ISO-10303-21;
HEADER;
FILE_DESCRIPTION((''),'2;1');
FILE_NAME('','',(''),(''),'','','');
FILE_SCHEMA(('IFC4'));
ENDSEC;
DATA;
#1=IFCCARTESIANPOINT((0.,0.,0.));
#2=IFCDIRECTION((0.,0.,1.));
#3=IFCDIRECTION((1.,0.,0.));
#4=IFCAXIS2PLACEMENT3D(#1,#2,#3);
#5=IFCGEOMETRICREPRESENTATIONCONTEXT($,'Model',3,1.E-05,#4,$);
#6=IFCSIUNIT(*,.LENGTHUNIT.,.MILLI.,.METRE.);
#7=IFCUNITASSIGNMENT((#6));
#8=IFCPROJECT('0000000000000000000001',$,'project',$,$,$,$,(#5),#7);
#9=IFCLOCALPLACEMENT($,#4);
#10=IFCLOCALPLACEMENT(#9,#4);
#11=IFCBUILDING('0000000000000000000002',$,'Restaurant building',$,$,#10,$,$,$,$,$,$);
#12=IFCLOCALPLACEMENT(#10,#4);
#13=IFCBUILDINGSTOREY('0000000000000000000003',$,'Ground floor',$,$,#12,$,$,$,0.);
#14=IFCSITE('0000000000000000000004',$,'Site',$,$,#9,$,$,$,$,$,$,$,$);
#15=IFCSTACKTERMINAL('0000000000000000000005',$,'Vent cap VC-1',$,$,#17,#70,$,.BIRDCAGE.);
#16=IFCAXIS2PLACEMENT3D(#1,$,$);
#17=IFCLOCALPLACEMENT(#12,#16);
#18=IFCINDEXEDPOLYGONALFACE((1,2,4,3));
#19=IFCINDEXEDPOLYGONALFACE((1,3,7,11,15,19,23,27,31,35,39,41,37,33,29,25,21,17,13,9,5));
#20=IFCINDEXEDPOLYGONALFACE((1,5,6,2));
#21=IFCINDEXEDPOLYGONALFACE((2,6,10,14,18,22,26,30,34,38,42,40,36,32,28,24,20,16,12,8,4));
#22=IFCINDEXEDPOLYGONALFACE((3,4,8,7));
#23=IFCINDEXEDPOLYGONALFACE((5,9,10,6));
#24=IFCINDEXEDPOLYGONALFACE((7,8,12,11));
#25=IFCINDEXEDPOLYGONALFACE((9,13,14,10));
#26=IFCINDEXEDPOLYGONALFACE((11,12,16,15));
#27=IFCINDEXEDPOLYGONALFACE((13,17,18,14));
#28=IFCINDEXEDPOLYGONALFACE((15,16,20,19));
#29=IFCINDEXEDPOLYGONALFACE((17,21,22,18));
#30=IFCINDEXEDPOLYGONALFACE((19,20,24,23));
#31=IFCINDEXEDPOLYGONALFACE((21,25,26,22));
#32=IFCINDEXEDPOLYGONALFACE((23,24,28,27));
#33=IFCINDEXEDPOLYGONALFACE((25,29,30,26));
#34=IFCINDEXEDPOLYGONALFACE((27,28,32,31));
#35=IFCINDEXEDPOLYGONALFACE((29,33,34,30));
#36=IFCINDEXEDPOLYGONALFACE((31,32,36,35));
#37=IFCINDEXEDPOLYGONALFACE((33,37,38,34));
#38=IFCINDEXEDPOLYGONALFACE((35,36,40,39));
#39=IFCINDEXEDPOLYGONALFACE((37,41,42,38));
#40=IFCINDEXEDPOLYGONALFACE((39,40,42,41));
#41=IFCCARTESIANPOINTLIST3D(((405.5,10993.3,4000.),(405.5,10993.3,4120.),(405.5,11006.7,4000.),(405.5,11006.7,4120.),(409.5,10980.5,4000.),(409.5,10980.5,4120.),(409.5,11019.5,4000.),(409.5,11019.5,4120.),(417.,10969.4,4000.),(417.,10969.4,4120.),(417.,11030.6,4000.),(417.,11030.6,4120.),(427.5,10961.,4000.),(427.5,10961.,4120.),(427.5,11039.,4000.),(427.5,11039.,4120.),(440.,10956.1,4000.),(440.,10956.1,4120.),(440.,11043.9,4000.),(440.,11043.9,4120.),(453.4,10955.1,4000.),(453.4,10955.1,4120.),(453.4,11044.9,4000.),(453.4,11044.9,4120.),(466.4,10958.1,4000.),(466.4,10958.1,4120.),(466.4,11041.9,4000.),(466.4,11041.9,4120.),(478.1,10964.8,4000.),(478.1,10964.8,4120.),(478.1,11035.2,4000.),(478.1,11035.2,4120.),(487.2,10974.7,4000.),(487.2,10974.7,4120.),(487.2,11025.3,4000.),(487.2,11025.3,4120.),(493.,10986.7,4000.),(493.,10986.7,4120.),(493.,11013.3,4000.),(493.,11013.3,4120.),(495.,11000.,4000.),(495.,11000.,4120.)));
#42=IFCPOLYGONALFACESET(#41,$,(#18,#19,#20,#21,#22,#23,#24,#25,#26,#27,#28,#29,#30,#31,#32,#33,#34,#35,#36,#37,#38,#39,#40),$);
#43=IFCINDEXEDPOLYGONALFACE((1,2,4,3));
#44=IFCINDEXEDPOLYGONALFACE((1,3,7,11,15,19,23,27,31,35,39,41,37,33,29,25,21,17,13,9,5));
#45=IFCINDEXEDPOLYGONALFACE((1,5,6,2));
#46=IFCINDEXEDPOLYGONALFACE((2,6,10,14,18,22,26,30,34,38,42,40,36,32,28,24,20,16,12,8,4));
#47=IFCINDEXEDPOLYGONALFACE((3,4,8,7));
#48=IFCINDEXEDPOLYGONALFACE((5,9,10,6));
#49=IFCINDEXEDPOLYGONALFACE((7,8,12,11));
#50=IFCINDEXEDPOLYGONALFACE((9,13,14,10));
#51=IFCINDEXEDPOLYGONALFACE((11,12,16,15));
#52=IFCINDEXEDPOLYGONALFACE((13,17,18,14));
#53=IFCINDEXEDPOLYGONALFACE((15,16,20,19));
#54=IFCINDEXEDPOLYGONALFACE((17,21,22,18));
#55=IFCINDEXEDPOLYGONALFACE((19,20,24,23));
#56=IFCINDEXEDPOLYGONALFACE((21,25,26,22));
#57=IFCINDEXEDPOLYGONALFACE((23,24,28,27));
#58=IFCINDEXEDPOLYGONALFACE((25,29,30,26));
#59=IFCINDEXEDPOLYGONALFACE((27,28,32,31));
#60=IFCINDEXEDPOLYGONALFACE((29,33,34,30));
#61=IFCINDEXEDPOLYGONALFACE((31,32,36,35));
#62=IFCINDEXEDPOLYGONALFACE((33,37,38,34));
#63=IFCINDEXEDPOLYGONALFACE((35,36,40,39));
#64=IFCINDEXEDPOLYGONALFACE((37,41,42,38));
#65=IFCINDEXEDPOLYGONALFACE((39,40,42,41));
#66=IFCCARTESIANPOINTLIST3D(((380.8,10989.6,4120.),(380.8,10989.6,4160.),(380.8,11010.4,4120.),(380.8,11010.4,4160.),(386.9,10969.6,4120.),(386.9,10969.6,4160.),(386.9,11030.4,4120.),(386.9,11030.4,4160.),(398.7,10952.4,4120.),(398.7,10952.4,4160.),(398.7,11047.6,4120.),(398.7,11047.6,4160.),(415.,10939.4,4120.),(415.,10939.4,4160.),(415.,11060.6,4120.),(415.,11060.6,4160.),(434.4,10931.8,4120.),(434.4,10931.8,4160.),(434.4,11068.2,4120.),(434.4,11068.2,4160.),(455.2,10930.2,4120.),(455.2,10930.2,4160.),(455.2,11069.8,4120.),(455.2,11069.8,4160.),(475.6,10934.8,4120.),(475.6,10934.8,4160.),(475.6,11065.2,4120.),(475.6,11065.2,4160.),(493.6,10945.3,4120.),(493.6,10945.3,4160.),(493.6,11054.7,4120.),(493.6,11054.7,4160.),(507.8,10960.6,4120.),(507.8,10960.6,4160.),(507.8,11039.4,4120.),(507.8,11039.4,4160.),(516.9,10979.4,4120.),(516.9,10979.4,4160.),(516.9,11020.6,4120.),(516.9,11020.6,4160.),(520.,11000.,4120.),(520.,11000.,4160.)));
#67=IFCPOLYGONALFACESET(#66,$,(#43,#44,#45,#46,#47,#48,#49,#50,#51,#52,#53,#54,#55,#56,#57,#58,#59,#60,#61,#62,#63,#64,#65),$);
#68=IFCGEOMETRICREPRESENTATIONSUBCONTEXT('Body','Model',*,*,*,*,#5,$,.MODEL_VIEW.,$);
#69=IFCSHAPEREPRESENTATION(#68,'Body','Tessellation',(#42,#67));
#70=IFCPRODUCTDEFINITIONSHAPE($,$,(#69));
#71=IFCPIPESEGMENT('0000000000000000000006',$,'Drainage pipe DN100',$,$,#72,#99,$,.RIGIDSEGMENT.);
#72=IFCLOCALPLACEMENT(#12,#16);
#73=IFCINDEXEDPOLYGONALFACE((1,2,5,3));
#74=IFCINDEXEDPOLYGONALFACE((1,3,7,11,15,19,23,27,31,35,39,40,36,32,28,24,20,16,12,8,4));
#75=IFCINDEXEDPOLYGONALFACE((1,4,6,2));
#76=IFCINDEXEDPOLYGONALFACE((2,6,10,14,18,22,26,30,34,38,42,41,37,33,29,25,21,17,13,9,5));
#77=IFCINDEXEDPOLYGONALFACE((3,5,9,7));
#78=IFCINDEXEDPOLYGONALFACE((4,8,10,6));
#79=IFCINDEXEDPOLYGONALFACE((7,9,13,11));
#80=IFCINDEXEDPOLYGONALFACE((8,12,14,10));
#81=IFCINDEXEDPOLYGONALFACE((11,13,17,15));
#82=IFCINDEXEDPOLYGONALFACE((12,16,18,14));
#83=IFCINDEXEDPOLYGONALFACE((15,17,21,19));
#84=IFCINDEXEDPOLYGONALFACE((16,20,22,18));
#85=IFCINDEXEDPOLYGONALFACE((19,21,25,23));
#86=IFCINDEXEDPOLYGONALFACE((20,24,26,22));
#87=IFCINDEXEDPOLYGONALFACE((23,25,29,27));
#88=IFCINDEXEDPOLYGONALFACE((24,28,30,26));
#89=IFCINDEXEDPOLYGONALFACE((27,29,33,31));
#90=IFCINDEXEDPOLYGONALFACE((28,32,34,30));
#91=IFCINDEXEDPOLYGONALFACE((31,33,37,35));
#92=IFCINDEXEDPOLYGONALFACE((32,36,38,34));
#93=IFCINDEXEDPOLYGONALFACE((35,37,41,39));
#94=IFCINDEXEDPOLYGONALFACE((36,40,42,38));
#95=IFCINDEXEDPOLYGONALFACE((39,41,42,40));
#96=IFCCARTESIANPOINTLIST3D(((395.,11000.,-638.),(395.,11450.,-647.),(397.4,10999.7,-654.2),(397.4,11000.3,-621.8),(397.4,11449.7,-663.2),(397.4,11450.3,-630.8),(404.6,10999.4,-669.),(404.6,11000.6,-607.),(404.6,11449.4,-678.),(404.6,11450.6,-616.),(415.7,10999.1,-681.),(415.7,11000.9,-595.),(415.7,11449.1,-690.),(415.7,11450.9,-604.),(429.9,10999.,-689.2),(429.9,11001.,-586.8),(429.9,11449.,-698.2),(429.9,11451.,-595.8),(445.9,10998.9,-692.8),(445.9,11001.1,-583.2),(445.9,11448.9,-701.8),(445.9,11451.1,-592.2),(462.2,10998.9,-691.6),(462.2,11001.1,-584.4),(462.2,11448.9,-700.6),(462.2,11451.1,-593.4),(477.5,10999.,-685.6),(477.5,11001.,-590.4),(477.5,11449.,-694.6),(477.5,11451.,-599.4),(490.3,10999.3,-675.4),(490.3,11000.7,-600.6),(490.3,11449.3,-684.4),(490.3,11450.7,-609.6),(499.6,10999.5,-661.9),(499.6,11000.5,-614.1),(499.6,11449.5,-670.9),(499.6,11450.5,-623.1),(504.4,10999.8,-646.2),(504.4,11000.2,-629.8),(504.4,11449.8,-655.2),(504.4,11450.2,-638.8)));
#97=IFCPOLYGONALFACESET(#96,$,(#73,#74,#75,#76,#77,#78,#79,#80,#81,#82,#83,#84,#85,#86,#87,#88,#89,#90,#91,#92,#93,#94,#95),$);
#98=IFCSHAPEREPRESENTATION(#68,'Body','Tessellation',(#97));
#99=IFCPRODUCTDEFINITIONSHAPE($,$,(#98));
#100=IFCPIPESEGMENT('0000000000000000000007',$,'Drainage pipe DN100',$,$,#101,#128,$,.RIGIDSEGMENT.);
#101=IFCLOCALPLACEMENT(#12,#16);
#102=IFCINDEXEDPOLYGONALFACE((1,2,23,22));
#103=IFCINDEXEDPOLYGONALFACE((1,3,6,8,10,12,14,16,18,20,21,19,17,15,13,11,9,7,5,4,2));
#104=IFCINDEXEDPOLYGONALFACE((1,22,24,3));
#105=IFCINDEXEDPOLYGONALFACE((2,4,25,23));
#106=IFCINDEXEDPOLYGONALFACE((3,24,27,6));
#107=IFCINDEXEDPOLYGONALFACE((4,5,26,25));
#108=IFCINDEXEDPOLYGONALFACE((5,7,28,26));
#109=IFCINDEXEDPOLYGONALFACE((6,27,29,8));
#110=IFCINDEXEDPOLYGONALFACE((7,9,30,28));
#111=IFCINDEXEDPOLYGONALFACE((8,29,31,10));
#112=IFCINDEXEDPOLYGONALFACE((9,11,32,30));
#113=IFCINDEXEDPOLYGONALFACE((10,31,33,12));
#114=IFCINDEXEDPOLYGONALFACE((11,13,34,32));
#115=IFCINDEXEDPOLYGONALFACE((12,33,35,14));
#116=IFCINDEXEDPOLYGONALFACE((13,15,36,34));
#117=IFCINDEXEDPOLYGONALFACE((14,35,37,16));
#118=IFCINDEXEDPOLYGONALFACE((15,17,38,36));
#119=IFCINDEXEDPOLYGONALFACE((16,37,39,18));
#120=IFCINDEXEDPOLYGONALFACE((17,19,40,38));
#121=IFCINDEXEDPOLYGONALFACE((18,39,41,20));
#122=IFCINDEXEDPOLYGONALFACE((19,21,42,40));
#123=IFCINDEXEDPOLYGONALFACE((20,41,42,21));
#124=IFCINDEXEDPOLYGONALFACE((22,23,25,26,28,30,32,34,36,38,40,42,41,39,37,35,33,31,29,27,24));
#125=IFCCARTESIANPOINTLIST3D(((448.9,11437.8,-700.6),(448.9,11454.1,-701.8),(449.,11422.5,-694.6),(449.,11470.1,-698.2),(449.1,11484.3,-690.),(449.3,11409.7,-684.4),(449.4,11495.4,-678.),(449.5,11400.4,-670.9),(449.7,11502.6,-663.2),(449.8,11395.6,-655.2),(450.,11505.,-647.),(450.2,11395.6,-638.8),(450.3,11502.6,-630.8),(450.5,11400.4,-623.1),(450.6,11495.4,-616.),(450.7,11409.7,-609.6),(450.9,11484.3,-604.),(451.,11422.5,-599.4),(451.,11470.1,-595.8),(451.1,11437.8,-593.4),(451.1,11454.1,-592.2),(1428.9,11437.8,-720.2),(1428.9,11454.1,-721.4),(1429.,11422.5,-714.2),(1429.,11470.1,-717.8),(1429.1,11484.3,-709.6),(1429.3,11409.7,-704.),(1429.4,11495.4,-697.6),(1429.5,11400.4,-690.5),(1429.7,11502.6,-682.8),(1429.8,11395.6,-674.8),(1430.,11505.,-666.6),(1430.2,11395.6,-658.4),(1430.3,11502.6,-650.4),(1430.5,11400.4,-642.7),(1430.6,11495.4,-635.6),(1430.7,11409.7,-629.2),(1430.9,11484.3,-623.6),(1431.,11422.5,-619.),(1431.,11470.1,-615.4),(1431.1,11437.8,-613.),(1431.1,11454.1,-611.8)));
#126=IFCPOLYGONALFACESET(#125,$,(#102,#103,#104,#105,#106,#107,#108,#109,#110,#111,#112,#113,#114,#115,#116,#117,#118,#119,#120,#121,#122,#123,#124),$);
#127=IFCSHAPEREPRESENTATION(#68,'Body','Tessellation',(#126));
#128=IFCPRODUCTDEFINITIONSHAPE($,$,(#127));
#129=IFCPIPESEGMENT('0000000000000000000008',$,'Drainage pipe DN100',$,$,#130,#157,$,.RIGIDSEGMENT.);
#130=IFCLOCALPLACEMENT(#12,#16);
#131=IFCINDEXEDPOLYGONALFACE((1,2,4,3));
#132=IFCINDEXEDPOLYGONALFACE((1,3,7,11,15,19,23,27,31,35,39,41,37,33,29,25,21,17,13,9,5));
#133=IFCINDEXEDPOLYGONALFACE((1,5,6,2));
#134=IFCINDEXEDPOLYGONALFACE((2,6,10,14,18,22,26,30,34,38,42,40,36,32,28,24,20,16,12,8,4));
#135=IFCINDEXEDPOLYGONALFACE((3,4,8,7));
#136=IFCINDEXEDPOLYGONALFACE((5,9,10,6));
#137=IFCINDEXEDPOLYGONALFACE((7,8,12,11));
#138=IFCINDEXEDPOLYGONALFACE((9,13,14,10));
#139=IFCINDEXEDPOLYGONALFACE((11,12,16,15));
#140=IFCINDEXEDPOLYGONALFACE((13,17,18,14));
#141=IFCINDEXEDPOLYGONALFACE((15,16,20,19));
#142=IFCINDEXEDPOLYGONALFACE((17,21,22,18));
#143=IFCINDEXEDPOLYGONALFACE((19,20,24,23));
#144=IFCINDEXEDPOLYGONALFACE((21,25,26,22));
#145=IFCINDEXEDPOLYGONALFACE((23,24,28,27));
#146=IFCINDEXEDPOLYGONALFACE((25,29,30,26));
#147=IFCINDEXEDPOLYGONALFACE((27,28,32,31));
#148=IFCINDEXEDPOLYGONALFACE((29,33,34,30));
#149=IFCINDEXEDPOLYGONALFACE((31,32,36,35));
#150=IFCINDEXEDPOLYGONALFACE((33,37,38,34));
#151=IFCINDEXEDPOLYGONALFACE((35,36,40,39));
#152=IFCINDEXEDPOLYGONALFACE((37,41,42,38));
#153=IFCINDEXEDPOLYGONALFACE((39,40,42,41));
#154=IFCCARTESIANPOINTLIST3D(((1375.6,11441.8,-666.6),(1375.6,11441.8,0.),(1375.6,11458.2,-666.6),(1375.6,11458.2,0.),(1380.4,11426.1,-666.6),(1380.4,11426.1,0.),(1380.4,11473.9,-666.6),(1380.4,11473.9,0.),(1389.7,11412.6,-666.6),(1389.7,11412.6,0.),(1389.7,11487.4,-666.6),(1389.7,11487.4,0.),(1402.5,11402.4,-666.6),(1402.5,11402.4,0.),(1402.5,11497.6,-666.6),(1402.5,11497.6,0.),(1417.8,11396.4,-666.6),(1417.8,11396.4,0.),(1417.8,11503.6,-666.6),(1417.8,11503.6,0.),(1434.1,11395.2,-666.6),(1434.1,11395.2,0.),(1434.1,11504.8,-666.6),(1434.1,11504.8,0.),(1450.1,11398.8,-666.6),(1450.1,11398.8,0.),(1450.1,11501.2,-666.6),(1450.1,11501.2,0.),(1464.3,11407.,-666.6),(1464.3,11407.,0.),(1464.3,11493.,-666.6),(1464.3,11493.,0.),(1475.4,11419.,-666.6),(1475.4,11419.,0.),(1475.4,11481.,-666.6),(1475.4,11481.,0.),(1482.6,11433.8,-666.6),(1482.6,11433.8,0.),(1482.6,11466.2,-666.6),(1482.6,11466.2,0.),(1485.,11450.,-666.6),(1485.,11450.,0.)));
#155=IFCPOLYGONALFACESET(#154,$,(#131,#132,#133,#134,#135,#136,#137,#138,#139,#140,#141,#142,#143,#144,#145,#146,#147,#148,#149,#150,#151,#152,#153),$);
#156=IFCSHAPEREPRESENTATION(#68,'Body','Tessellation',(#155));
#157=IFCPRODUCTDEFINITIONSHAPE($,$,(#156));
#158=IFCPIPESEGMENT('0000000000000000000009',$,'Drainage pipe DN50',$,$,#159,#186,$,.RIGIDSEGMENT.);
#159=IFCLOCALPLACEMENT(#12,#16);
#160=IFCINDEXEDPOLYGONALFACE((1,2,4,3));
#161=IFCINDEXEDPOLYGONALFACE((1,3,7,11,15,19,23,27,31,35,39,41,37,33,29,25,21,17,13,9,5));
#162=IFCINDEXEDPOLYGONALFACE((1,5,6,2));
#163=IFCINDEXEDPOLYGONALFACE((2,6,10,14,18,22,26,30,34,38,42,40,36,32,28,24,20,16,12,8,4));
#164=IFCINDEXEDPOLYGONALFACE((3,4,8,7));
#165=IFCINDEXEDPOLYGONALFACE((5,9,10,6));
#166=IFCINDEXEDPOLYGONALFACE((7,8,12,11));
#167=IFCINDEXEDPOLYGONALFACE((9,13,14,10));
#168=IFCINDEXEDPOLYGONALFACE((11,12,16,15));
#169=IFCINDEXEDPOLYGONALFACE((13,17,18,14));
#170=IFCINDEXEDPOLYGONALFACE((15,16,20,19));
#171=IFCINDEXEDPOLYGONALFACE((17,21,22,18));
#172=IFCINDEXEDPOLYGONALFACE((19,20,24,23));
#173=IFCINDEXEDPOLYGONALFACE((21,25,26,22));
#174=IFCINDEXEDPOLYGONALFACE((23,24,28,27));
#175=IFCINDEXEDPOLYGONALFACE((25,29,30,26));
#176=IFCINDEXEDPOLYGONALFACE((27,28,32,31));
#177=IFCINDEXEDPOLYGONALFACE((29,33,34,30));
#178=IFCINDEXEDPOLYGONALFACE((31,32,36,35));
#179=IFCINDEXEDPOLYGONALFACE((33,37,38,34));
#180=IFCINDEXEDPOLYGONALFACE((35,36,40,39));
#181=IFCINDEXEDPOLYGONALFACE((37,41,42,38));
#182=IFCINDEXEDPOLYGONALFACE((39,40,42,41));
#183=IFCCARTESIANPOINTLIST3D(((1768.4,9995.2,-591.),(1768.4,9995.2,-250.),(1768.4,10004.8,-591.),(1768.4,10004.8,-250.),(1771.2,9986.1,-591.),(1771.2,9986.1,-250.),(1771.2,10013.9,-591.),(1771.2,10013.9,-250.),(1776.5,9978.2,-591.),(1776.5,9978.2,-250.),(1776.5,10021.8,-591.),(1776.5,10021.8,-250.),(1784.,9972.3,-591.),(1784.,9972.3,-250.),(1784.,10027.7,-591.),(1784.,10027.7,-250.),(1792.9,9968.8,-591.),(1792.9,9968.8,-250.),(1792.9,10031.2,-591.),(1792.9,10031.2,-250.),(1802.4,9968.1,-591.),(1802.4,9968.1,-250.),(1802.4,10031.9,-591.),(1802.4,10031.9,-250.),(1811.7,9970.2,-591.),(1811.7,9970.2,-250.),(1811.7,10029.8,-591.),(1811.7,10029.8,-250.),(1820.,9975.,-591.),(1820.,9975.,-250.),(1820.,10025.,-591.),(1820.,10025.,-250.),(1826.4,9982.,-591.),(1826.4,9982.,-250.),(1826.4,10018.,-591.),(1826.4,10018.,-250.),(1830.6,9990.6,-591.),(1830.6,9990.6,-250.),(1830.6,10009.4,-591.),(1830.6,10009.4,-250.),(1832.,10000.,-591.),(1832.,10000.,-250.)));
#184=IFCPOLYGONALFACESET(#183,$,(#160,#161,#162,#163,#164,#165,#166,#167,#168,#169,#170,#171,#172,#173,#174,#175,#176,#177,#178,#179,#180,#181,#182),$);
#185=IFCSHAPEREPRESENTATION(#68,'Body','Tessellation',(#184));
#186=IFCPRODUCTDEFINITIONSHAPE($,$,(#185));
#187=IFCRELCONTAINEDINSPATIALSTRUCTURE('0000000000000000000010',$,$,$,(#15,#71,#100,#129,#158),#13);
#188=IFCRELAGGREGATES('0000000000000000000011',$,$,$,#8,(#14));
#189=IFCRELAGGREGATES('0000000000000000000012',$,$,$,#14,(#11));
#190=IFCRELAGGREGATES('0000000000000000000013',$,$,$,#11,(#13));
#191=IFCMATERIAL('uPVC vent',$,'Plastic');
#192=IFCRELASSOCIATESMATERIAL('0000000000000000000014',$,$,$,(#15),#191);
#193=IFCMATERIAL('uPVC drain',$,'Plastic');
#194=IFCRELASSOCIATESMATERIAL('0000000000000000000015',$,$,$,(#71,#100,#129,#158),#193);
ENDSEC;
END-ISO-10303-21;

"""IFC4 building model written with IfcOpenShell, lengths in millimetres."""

from ifc_helpers import new_model, si_unit, frame, origin_with_axes, origin_2d, place, context, subcontext, project, spatial, circle, extrude, material, element, save


model = new_model("IFC4")

# Units and contexts
model_context = context("Model", 3, precision=1e-05, world=origin_with_axes())
body_context = subcontext(model_context, "Body", "Model", "MODEL_VIEW")
ifc_project = project(units=[si_unit("LENGTHUNIT", "METRE", prefix="MILLI")], contexts=[model_context])

# Site, building, storey
site_placement = place(None, origin_with_axes())
site = spatial("IfcSite", under=ifc_project, at=site_placement, Name="Site")
building_placement = place(site_placement, origin_with_axes())
building = spatial("IfcBuilding", under=site, at=building_placement, Name="Restaurant building")
storey_placement = place(building_placement, origin_with_axes())
storey = spatial("IfcBuildingStorey", under=building, at=storey_placement, Name="Ground floor", Elevation=0.0)

# Shared definitions
ifc_material_1 = material(Name="uPVC drain", Category="Plastic")

# Stack terminal
ifc_material_2 = material(Name="uPVC vent", Category="Plastic")
stack_terminal_1_placement = place(storey_placement, frame((450.0, 11000.0, 0.0)))
element("IfcStackTerminal", 1, at=stack_terminal_1_placement, inside=storey, material=ifc_material_2, Name="Vent cap VC-1", PredefinedType="BIRDCAGE", context=body_context, shape_type="SweptSolid", body=[
    extrude(circle(Radius=45.0, at=origin_2d()), frame((0.0, 0.0, 4000.0)), (0.0, 0.0, 1.0), 120.0),
    extrude(circle(Radius=70.0, at=origin_2d()), frame((0.0, 0.0, 4120.0)), (0.0, 0.0, 1.0), 40.0),
])

# Pipe segments
pipe_segment_1_placement = place(storey_placement, frame((450.0, 11000.0, -638.0)))
element("IfcPipeSegment", 2, at=pipe_segment_1_placement, inside=storey, material=ifc_material_1, Name="Drainage pipe DN100", PredefinedType="RIGIDSEGMENT", context=body_context, shape_type="SweptSolid", body=[
    extrude(circle(Radius=55.0, at=origin_2d()), frame((0.0, 0.0, 0.0), z_axis=(0.0, 0.9998, -0.019996), x_axis=(-1.0, 0.0, 0.0)), (0.0, 0.0, 1.0), 450.1),
])
pipe_segment_2_placement = place(storey_placement, frame((450.0, 11450.0, -647.0)))
element("IfcPipeSegment", 3, at=pipe_segment_2_placement, inside=storey, material=ifc_material_1, Name="Drainage pipe DN100", PredefinedType="RIGIDSEGMENT", context=body_context, shape_type="SweptSolid", body=[
    extrude(circle(Radius=55.0, at=origin_2d()), frame((0.0, 0.0, 0.0), z_axis=(0.9998, 0.0, -0.019996), x_axis=(0.0, 1.0, 0.0)), (0.0, 0.0, 1.0), 980.2),
])
pipe_segment_3_placement = place(storey_placement, frame((1430.0, 11450.0, 0.0)))
element("IfcPipeSegment", 4, at=pipe_segment_3_placement, inside=storey, material=ifc_material_1, Name="Drainage pipe DN100", PredefinedType="RIGIDSEGMENT", context=body_context, shape_type="SweptSolid", body=[
    extrude(circle(Radius=55.0, at=origin_2d()), frame((0.0, 0.0, 0.0), z_axis=(0.0, 0.0, -1.0), x_axis=(1.0, 0.0, 0.0)), (0.0, 0.0, 1.0), 666.6),
])
pipe_segment_4_placement = place(storey_placement, frame((1800.0, 10000.0, -250.0)))
element("IfcPipeSegment", 5, at=pipe_segment_4_placement, inside=storey, material=ifc_material_1, Name="Drainage pipe DN50", PredefinedType="RIGIDSEGMENT", context=body_context, shape_type="SweptSolid", body=[
    extrude(circle(Radius=32.0, at=origin_2d()), frame((0.0, 0.0, 0.0), z_axis=(0.0, 0.0, -1.0), x_axis=(1.0, 0.0, 0.0)), (0.0, 0.0, 1.0), 341.0),
])

save(model, "model.ifc")
